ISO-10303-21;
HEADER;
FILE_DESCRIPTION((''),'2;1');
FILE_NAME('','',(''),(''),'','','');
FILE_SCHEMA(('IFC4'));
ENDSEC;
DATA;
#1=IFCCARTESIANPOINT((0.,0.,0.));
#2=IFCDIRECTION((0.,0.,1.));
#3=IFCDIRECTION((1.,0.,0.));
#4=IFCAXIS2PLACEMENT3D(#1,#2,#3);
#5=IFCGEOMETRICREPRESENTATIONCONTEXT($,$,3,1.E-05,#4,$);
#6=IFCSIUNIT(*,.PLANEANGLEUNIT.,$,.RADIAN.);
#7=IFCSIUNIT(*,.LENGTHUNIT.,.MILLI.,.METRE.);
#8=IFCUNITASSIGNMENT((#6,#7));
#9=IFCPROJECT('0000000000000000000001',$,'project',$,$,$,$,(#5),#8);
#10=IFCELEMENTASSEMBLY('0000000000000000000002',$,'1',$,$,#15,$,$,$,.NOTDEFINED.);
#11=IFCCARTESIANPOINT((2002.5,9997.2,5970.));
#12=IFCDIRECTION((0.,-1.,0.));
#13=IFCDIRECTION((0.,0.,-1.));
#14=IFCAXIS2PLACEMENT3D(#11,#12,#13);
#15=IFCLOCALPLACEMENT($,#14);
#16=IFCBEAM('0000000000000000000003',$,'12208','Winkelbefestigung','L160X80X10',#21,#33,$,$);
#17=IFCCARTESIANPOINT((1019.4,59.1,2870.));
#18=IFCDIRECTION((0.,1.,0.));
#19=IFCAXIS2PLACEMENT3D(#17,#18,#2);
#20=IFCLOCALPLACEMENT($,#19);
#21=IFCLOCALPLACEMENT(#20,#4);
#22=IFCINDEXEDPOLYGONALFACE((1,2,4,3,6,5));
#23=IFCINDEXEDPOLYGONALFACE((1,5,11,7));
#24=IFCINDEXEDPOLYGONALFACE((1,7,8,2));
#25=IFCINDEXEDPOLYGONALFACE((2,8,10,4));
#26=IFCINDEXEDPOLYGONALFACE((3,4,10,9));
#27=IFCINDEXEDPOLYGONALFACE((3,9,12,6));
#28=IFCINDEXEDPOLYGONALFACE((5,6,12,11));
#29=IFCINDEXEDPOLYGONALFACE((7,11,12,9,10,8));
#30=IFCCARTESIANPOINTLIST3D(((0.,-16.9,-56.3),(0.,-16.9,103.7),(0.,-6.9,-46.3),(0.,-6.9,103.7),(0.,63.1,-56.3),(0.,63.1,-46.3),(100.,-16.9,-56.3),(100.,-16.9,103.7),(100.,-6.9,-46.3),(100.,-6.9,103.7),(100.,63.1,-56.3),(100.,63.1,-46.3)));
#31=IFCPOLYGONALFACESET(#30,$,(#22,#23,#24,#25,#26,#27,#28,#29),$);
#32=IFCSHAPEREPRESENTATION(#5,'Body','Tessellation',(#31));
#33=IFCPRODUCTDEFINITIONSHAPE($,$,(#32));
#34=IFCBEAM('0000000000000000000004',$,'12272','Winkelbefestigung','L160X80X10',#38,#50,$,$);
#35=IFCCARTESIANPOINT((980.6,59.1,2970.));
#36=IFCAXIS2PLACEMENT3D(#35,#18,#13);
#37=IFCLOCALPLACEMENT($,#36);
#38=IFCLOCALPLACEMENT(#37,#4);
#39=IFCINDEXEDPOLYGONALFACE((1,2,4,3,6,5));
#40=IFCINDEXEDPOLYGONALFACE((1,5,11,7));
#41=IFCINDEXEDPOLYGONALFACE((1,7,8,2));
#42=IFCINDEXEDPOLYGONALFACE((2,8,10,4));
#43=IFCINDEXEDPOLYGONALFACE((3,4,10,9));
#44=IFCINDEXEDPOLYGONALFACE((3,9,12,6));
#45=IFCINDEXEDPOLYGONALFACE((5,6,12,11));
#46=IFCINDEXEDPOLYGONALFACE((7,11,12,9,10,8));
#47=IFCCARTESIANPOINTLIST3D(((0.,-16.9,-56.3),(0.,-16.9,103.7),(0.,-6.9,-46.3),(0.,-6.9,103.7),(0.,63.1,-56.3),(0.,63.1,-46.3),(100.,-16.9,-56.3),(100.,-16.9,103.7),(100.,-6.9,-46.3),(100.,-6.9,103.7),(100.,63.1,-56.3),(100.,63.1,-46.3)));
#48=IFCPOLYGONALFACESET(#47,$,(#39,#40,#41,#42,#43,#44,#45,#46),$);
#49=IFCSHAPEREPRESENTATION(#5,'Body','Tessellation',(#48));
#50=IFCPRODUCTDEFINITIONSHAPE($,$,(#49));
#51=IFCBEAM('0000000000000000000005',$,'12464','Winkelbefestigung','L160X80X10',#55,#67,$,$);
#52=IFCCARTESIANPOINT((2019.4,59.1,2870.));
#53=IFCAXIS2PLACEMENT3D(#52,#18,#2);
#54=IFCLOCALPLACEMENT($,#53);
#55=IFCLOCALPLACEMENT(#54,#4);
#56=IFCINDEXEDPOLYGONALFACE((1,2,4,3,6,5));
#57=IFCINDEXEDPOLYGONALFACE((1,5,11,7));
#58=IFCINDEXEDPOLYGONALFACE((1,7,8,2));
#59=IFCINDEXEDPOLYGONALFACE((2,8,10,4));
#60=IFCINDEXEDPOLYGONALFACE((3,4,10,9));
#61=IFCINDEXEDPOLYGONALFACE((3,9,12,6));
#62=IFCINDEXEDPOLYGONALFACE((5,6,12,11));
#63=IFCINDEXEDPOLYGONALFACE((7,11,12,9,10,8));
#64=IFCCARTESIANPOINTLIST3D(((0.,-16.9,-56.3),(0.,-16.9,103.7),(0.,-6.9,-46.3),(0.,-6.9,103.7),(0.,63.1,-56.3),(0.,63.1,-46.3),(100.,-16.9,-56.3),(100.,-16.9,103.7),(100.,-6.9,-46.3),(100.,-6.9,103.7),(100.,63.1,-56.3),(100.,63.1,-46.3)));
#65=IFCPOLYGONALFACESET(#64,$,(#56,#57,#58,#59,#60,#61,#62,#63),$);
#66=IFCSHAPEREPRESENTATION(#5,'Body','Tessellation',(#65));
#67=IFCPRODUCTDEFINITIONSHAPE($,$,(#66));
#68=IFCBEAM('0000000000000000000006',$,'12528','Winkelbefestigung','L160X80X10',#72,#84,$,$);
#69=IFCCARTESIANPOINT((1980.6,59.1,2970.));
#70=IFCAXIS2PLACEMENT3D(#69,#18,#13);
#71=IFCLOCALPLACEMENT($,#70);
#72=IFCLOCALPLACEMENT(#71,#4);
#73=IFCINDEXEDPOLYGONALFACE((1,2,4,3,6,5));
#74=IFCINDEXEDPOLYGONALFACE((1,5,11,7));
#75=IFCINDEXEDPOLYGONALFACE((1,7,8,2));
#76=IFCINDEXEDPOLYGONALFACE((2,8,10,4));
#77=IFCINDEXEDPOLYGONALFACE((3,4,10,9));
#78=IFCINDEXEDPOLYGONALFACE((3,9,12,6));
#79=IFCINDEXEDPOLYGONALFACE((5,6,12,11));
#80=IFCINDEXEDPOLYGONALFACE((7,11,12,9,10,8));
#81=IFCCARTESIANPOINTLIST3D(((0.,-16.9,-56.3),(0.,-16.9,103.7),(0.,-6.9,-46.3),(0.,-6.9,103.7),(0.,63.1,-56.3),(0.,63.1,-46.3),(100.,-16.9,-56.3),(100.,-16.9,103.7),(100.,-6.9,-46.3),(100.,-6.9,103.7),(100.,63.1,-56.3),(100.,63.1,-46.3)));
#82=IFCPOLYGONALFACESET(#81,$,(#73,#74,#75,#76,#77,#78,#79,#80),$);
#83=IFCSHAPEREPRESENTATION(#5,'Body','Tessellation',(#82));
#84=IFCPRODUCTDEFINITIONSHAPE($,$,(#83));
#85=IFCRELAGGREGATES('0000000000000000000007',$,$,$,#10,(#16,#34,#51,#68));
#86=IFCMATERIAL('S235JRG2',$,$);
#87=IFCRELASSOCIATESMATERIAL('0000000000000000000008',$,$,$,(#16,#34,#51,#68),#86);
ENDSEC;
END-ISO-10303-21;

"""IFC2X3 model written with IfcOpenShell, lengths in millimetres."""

from ifc_helpers import new_model, si_unit, frame, origin_with_axes, place, context, project, polyline, outline, extrude, material, element, aggregate, save


model = new_model("IFC2X3")

# Units and contexts
context_of_model = context(None, 3, precision=1e-05, world=origin_with_axes())
ifc_project = project(units=[si_unit("PLANEANGLEUNIT", "RADIAN"), si_unit("LENGTHUNIT", "METRE", prefix="MILLI")], contexts=[context_of_model])

# Shared definitions
ifc_material = material(Name="S235JRG2")

# Element assembly, beams
assembly_1_placement = place(None, frame((2002.5, 9997.2, 5970.0), z_axis=(0.0, -1.0, 0.0), x_axis=(0.0, 0.0, -1.0)))
assembly_1 = element("IfcElementAssembly", 1, at=assembly_1_placement, Name="1", PredefinedType="NOTDEFINED")
placement_1 = place(None, frame((1019.4, 59.1, 2870.0), z_axis=(0.0, 1.0, 0.0), x_axis=(0.0, 0.0, 1.0)))
beam_1_placement = place(placement_1, origin_with_axes())
beam_1 = element("IfcBeam", 2, at=beam_1_placement, material=ifc_material, Name="12208", Description="Winkelbefestigung", ObjectType="L160X80X10", context=context_of_model, shape_type="SweptSolid", body=[
    extrude(outline(polyline([(-16.9, 103.7), (-16.9, -56.3), (63.1, -56.3), (63.1, -46.3), (-6.9, -46.3), (-6.9, 103.7), (-16.9, 103.7), (-16.9, 103.7)])), frame((0.0, 0.0, 0.0), z_axis=(1.0, 0.0, 0.0), x_axis=(0.0, 1.0, 0.0)), (0.0, 0.0, 1.0), 100.0),
])
placement_2 = place(None, frame((980.6, 59.1, 2970.0), z_axis=(0.0, 1.0, 0.0), x_axis=(0.0, 0.0, -1.0)))
beam_2_placement = place(placement_2, origin_with_axes())
beam_2 = element("IfcBeam", 3, at=beam_2_placement, material=ifc_material, Name="12272", Description="Winkelbefestigung", ObjectType="L160X80X10", context=context_of_model, shape_type="SweptSolid", body=[
    extrude(outline(polyline([(-16.9, 103.7), (-16.9, -56.3), (63.1, -56.3), (63.1, -46.3), (-6.9, -46.3), (-6.9, 103.7), (-16.9, 103.7), (-16.9, 103.7)])), frame((0.0, 0.0, 0.0), z_axis=(1.0, 0.0, 0.0), x_axis=(0.0, 1.0, 0.0)), (0.0, 0.0, 1.0), 100.0),
])
placement_3 = place(None, frame((2019.4, 59.1, 2870.0), z_axis=(0.0, 1.0, 0.0), x_axis=(0.0, 0.0, 1.0)))
beam_3_placement = place(placement_3, origin_with_axes())
beam_3 = element("IfcBeam", 4, at=beam_3_placement, material=ifc_material, Name="12464", Description="Winkelbefestigung", ObjectType="L160X80X10", context=context_of_model, shape_type="SweptSolid", body=[
    extrude(outline(polyline([(-16.9, 103.7), (-16.9, -56.3), (63.1, -56.3), (63.1, -46.3), (-6.9, -46.3), (-6.9, 103.7), (-16.9, 103.7), (-16.9, 103.7)])), frame((0.0, 0.0, 0.0), z_axis=(1.0, 0.0, 0.0), x_axis=(0.0, 1.0, 0.0)), (0.0, 0.0, 1.0), 100.0),
])
placement_4 = place(None, frame((1980.6, 59.1, 2970.0), z_axis=(0.0, 1.0, 0.0), x_axis=(0.0, 0.0, -1.0)))
beam_4_placement = place(placement_4, origin_with_axes())
beam_4 = element("IfcBeam", 5, at=beam_4_placement, material=ifc_material, Name="12528", Description="Winkelbefestigung", ObjectType="L160X80X10", context=context_of_model, shape_type="SweptSolid", body=[
    extrude(outline(polyline([(-16.9, 103.7), (-16.9, -56.3), (63.1, -56.3), (63.1, -46.3), (-6.9, -46.3), (-6.9, 103.7), (-16.9, 103.7), (-16.9, 103.7)])), frame((0.0, 0.0, 0.0), z_axis=(1.0, 0.0, 0.0), x_axis=(0.0, 1.0, 0.0)), (0.0, 0.0, 1.0), 100.0),
])
aggregate(assembly_1, [beam_1, beam_2, beam_3, beam_4])

save(model, "model.ifc")
